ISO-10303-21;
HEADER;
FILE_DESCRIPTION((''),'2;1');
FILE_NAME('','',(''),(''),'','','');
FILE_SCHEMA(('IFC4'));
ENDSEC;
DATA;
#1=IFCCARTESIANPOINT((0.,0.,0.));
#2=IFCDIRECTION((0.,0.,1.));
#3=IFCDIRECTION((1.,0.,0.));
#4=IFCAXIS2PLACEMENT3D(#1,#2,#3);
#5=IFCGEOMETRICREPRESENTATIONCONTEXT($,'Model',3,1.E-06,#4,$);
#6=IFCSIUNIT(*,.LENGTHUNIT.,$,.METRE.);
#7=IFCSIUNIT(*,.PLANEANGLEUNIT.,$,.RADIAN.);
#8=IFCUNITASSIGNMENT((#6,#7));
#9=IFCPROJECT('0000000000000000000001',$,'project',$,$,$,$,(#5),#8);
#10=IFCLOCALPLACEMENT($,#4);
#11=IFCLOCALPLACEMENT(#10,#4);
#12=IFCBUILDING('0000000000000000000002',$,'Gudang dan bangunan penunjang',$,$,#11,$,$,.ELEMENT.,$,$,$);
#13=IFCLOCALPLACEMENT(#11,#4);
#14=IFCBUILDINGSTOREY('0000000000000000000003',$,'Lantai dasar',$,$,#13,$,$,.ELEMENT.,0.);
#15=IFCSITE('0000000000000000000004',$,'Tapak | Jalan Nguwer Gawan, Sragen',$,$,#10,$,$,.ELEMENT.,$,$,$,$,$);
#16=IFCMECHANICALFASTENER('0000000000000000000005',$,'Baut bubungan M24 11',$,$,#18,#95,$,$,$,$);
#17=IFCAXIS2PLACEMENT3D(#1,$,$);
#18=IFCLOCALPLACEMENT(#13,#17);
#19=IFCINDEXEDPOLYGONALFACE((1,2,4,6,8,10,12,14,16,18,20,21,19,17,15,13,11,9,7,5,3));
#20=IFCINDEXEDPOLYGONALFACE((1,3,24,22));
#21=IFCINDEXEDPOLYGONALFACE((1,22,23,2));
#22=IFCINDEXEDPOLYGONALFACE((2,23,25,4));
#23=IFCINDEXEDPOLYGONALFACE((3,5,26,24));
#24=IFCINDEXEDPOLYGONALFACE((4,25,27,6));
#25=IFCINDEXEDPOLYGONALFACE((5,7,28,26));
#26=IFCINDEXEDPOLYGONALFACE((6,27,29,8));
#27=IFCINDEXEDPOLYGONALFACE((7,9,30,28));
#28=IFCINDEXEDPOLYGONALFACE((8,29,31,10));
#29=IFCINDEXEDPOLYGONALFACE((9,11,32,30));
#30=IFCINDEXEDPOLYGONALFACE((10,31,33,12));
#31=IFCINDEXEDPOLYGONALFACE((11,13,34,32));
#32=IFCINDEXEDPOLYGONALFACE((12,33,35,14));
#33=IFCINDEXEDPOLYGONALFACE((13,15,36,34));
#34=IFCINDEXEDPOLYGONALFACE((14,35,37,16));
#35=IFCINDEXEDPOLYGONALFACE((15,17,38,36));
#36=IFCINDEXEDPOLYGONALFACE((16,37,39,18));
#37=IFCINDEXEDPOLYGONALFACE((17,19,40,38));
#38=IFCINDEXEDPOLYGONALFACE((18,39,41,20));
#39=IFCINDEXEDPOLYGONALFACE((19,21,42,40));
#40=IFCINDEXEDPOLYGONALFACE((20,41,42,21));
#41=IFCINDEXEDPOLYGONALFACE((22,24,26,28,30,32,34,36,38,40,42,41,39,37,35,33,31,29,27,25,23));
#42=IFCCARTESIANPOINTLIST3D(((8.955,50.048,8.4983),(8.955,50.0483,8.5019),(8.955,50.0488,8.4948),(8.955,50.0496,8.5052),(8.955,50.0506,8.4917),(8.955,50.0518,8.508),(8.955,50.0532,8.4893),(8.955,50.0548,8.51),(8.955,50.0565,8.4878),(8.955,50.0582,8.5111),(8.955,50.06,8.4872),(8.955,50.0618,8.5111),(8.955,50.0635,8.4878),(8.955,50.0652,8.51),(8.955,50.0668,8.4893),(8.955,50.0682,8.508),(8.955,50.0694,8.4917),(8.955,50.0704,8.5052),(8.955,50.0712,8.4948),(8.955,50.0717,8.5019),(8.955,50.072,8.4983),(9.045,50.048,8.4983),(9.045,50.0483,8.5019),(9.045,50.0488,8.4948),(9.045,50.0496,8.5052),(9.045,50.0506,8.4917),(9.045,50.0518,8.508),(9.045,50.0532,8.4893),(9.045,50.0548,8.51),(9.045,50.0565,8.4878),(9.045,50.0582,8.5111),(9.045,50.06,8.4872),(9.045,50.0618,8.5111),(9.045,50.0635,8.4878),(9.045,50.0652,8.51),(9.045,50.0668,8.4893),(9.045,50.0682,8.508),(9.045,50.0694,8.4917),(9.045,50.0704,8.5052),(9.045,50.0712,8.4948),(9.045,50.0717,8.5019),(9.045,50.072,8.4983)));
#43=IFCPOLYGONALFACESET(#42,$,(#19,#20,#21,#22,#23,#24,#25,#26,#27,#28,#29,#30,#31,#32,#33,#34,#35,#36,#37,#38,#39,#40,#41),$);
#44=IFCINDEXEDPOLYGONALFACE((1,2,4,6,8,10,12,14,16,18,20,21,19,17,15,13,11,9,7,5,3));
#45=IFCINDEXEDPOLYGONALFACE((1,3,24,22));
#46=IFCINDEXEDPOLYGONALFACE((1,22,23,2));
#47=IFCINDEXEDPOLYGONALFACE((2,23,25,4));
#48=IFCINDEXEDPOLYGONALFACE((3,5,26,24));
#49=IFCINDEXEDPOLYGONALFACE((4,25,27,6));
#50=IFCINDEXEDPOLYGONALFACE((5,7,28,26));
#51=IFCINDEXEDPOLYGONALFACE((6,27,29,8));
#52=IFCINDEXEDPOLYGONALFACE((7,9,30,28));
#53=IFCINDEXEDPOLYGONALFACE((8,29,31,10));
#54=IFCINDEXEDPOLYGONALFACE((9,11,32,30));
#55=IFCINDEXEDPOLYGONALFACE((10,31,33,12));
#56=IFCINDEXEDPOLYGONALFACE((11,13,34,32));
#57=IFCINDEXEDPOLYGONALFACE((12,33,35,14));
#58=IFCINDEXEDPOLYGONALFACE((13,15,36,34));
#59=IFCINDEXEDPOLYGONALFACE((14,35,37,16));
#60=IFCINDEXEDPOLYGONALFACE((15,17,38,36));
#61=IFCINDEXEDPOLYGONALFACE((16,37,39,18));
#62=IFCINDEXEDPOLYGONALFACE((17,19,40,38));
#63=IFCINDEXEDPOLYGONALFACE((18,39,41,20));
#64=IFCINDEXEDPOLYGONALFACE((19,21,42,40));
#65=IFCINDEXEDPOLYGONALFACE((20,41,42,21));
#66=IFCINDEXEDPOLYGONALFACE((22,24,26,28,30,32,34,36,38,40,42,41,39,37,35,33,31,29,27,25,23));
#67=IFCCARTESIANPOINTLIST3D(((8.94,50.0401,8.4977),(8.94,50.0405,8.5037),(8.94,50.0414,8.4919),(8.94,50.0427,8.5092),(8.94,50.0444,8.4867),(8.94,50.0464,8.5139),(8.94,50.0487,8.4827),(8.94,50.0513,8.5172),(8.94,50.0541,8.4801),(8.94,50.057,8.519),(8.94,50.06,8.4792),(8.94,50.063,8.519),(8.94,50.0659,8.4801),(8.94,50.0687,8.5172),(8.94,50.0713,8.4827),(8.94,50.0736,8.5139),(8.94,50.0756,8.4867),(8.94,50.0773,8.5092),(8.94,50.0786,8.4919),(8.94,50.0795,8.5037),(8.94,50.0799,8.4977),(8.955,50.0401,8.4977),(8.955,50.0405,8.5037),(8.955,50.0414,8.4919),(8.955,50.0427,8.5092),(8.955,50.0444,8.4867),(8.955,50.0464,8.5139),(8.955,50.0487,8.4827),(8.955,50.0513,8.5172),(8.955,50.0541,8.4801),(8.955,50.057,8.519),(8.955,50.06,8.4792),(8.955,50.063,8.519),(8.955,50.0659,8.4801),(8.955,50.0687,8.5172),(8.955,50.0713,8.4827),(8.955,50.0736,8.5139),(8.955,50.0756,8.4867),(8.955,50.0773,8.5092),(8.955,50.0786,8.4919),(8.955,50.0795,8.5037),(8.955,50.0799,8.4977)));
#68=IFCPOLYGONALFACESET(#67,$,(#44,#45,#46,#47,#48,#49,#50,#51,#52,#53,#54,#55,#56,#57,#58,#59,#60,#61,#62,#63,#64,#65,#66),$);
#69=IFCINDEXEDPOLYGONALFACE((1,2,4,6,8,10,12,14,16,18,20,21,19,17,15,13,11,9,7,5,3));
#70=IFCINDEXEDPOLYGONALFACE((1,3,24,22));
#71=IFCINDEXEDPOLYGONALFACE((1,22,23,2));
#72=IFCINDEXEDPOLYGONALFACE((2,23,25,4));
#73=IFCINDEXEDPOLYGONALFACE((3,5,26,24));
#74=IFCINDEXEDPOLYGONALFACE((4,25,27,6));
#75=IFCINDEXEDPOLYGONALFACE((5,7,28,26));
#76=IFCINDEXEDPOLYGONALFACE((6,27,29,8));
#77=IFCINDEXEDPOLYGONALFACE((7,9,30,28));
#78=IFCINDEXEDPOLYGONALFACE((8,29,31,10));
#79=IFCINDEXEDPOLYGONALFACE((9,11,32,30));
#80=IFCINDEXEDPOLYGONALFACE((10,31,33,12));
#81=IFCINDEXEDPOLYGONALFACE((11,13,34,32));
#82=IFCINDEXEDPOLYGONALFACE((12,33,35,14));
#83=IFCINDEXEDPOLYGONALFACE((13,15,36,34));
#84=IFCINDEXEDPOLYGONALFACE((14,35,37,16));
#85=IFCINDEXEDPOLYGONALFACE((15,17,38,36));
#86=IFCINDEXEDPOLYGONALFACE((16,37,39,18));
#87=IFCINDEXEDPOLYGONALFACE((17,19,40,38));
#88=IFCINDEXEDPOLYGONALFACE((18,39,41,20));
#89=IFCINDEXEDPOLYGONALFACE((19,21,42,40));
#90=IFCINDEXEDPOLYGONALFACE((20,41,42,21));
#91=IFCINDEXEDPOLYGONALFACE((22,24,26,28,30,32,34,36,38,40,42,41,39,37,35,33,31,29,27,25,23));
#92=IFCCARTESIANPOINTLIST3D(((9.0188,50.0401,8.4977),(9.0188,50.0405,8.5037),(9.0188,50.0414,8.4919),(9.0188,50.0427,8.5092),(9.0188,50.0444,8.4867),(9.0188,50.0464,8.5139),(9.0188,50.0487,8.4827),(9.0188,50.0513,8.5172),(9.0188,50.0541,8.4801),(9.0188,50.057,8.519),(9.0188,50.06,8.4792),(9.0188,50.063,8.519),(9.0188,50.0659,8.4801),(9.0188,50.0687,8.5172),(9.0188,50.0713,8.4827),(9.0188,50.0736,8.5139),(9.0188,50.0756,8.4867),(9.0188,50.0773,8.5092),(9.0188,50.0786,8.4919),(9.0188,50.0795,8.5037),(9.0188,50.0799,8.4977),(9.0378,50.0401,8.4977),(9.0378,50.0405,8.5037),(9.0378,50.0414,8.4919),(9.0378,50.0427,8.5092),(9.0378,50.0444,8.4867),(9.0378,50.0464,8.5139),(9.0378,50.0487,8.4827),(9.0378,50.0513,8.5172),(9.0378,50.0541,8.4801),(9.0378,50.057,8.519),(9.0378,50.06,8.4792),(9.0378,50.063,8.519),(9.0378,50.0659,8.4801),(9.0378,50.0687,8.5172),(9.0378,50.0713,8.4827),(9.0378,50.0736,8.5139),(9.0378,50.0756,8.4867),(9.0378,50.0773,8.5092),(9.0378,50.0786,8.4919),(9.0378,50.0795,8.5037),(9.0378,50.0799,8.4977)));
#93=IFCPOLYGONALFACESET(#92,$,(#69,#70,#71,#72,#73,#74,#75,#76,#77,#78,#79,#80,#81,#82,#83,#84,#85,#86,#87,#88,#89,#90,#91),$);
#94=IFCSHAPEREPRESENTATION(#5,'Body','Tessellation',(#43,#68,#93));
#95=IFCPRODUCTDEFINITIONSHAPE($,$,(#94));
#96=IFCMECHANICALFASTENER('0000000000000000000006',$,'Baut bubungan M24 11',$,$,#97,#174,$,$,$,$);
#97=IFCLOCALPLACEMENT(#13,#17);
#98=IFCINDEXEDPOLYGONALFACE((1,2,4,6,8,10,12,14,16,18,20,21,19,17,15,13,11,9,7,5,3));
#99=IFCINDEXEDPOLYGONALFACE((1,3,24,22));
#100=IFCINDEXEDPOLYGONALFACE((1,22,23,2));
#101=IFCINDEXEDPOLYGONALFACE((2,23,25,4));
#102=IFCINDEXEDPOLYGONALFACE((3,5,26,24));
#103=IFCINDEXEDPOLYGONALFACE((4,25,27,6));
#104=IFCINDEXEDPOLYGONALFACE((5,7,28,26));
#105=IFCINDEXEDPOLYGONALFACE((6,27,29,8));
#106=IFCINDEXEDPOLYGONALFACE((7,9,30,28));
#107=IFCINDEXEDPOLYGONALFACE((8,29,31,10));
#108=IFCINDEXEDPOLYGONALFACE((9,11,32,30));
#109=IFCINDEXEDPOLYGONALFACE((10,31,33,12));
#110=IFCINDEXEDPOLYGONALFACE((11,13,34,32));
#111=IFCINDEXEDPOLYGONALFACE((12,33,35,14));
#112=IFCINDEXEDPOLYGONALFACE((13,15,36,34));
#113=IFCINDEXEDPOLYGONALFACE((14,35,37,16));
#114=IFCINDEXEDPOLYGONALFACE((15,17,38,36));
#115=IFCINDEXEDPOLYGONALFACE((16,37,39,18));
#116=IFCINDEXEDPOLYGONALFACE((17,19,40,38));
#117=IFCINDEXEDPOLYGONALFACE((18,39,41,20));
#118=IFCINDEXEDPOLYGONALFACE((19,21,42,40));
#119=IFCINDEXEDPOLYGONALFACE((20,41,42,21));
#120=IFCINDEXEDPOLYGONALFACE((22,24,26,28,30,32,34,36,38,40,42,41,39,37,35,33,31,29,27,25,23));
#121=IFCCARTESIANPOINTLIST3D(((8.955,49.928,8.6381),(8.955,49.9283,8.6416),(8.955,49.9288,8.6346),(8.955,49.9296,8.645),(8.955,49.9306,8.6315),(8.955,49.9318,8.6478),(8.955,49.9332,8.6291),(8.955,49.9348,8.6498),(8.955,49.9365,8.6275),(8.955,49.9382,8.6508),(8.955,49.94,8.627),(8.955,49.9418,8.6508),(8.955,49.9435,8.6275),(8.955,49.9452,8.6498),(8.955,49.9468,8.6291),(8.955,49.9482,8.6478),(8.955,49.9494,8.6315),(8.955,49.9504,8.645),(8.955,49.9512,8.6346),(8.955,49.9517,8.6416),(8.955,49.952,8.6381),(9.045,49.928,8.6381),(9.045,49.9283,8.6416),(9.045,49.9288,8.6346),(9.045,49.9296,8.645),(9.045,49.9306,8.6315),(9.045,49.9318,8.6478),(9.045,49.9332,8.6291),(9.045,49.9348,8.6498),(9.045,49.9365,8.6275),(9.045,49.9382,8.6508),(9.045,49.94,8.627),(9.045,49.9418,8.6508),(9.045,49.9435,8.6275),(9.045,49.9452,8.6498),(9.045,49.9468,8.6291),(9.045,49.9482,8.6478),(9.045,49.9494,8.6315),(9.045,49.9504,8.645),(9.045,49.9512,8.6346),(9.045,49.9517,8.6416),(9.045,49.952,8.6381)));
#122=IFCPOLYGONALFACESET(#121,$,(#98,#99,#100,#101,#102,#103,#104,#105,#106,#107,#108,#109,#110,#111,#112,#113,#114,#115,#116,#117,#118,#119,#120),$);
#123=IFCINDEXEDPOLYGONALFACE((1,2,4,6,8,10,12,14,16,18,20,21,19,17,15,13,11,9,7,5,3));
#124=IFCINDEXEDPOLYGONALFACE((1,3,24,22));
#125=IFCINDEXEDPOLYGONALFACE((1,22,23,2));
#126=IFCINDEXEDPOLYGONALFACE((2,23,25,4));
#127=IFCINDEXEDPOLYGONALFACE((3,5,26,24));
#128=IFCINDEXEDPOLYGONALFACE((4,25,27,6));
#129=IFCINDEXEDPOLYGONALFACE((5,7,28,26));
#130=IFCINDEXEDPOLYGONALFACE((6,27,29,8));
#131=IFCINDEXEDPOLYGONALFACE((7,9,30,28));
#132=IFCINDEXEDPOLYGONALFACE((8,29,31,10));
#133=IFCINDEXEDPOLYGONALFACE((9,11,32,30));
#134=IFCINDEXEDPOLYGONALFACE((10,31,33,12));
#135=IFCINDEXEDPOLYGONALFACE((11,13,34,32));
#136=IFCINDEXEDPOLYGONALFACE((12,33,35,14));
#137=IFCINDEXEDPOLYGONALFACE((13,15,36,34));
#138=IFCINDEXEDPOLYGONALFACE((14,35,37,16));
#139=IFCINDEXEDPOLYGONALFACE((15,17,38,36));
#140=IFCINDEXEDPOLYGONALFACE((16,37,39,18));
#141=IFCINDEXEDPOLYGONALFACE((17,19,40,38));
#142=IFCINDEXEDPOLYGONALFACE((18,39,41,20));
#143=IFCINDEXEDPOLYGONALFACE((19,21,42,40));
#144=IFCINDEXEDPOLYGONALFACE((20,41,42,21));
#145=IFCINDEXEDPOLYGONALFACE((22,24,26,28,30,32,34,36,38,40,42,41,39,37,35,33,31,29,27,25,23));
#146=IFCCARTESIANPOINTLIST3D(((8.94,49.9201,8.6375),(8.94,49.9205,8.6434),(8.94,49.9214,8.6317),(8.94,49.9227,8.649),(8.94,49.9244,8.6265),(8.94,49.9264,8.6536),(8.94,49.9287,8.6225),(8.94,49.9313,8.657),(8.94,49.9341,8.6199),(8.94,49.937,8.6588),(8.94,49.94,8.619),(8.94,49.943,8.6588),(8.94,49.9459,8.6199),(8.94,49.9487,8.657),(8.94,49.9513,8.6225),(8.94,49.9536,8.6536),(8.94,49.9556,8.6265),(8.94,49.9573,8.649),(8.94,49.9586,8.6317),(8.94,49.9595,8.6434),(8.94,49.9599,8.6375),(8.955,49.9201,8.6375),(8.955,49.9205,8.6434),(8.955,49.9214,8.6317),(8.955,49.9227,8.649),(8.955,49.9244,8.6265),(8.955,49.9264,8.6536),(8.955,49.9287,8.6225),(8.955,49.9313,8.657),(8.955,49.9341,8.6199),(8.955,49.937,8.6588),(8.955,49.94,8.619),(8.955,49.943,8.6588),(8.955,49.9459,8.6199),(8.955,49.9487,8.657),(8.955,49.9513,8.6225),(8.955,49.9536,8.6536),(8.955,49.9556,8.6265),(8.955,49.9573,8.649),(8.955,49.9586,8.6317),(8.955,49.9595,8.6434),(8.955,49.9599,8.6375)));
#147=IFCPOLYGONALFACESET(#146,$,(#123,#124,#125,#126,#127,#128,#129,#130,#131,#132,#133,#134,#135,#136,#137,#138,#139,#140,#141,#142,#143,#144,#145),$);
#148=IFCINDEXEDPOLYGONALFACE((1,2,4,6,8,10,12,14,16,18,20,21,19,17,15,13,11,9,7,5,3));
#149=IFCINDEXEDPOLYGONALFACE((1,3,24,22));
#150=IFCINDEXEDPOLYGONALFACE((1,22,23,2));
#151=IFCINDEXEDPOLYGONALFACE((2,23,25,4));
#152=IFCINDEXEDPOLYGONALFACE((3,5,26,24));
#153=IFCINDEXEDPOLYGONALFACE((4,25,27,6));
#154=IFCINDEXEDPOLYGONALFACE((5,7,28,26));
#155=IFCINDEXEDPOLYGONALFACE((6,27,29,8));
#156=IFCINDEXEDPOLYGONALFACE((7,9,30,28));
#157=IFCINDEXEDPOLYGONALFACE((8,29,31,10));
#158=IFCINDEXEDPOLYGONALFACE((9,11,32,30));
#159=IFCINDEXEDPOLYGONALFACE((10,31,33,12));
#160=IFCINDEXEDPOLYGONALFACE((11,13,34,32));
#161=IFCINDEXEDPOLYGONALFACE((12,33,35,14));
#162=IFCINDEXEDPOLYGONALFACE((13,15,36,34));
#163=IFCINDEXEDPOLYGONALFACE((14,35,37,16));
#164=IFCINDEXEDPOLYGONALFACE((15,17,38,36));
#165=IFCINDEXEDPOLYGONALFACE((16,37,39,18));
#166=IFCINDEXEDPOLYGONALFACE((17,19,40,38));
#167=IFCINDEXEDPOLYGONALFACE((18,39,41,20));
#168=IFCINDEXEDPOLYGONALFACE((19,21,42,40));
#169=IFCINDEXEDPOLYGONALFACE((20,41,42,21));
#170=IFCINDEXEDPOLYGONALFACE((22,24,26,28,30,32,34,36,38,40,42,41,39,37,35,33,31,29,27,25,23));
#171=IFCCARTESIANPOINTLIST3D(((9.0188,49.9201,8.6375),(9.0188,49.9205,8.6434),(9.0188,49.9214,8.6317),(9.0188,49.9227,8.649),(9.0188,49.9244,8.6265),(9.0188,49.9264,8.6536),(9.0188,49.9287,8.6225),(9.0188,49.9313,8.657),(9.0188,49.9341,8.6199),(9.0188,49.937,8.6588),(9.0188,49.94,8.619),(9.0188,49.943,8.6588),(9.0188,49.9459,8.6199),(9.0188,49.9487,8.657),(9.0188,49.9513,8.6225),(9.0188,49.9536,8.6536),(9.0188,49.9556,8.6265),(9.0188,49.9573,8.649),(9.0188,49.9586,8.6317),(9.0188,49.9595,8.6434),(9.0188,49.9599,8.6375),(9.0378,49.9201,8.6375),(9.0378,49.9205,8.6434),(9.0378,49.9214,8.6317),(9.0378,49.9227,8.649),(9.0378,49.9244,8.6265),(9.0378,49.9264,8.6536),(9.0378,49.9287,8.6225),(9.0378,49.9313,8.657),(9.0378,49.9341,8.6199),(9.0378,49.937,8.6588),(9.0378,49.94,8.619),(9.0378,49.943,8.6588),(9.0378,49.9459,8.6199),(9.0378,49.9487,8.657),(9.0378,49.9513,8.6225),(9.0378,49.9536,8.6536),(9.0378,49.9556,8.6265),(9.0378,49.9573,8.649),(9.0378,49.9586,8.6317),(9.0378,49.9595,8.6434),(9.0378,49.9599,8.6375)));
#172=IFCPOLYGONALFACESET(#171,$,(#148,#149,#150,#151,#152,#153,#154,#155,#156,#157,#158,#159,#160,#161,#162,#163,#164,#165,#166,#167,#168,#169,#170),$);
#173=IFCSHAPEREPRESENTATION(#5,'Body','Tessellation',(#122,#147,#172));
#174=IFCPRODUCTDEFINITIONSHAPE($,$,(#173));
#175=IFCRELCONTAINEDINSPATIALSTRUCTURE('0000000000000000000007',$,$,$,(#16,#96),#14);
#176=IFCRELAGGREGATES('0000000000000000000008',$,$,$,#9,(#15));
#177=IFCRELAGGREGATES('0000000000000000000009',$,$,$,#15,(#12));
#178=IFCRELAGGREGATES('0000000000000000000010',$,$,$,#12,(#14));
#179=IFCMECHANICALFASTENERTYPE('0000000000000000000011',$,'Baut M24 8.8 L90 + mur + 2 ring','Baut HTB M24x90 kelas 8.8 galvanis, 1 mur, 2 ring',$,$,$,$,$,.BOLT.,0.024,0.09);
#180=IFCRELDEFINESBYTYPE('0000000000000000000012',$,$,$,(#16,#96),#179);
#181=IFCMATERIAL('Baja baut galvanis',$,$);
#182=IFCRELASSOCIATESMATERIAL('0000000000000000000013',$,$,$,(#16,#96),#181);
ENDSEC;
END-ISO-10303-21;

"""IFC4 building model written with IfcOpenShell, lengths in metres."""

from ifc_helpers import new_model, si_unit, frame, origin_with_axes, place, context, project, spatial, circle, extrude, source, transform, mapped, material, type_object, type_shapes, element, save


model = new_model("IFC4")

# Units and contexts
model_context = context("Model", 3, precision=1e-06, world=origin_with_axes())
ifc_project = project(units=[si_unit("LENGTHUNIT", "METRE"), si_unit("PLANEANGLEUNIT", "RADIAN")], contexts=[model_context])

# Site, building, storey
site_placement = place(None, origin_with_axes())
site = spatial("IfcSite", under=ifc_project, at=site_placement, Name="Tapak | Jalan Nguwer Gawan, Sragen", CompositionType="ELEMENT")
building_placement = place(site_placement, origin_with_axes())
building = spatial("IfcBuilding", under=site, at=building_placement, Name="Gudang dan bangunan penunjang", CompositionType="ELEMENT")
storey_placement = place(building_placement, origin_with_axes())
storey = spatial("IfcBuildingStorey", under=building, at=storey_placement, Name="Lantai dasar", CompositionType="ELEMENT", Elevation=0.0)

# Shared definitions
placement = place(None, origin_with_axes())

# Mechanical fasteners
ifc_material_1 = material(Name="Baja baut galvanis")
mechanical_fastener_type_1 = type_object("IfcMechanicalFastenerType", Name="Baut M24 8.8 L90 + mur + 2 ring", Description="Baut HTB M24x90 kelas 8.8 galvanis, 1 mur, 2 ring", NominalDiameter=0.024, NominalLength=0.09, PredefinedType="BOLT")
shared_shape_1 = source(origin_with_axes(), model_context, "Body", "SweptSolid", [
    extrude(circle(Radius=0.012), origin_with_axes(), (0.0, 0.0, 1.0), 0.09),
    extrude(circle(Radius=0.02), frame((0.0, 0.0, -0.015), z_axis=(0.0, 0.0, 1.0), x_axis=(1.0, 0.0, 0.0)), (0.0, 0.0, 1.0), 0.015),
    extrude(circle(Radius=0.02), frame((0.0, 0.0, 0.0638), z_axis=(0.0, 0.0, 1.0), x_axis=(1.0, 0.0, 0.0)), (0.0, 0.0, 1.0), 0.019),
])
type_shapes(mechanical_fastener_type_1, [shared_shape_1])
element("IfcMechanicalFastener", 1, at=placement, inside=storey, type_object=mechanical_fastener_type_1, material=ifc_material_1, Name="Baut bubungan M24 11", context=model_context, shape_type="MappedRepresentation", body=[
    mapped(shared_shape_1, transform((8.955, 50.06, 8.4992), x_axis=(0.0, 0.0, -1.0), y_axis=(0.0, 1.0, 0.0), z_axis=(1.0, 0.0, 0.0), scale=1.0)),
])
element("IfcMechanicalFastener", 2, at=placement, inside=storey, type_object=mechanical_fastener_type_1, material=ifc_material_1, Name="Baut bubungan M24 11", context=model_context, shape_type="MappedRepresentation", body=[
    mapped(shared_shape_1, transform((8.955, 49.94, 8.639), x_axis=(0.0, 0.0, -1.0), y_axis=(0.0, 1.0, 0.0), z_axis=(1.0, 0.0, 0.0), scale=1.0)),
])

save(model, "model.ifc")
